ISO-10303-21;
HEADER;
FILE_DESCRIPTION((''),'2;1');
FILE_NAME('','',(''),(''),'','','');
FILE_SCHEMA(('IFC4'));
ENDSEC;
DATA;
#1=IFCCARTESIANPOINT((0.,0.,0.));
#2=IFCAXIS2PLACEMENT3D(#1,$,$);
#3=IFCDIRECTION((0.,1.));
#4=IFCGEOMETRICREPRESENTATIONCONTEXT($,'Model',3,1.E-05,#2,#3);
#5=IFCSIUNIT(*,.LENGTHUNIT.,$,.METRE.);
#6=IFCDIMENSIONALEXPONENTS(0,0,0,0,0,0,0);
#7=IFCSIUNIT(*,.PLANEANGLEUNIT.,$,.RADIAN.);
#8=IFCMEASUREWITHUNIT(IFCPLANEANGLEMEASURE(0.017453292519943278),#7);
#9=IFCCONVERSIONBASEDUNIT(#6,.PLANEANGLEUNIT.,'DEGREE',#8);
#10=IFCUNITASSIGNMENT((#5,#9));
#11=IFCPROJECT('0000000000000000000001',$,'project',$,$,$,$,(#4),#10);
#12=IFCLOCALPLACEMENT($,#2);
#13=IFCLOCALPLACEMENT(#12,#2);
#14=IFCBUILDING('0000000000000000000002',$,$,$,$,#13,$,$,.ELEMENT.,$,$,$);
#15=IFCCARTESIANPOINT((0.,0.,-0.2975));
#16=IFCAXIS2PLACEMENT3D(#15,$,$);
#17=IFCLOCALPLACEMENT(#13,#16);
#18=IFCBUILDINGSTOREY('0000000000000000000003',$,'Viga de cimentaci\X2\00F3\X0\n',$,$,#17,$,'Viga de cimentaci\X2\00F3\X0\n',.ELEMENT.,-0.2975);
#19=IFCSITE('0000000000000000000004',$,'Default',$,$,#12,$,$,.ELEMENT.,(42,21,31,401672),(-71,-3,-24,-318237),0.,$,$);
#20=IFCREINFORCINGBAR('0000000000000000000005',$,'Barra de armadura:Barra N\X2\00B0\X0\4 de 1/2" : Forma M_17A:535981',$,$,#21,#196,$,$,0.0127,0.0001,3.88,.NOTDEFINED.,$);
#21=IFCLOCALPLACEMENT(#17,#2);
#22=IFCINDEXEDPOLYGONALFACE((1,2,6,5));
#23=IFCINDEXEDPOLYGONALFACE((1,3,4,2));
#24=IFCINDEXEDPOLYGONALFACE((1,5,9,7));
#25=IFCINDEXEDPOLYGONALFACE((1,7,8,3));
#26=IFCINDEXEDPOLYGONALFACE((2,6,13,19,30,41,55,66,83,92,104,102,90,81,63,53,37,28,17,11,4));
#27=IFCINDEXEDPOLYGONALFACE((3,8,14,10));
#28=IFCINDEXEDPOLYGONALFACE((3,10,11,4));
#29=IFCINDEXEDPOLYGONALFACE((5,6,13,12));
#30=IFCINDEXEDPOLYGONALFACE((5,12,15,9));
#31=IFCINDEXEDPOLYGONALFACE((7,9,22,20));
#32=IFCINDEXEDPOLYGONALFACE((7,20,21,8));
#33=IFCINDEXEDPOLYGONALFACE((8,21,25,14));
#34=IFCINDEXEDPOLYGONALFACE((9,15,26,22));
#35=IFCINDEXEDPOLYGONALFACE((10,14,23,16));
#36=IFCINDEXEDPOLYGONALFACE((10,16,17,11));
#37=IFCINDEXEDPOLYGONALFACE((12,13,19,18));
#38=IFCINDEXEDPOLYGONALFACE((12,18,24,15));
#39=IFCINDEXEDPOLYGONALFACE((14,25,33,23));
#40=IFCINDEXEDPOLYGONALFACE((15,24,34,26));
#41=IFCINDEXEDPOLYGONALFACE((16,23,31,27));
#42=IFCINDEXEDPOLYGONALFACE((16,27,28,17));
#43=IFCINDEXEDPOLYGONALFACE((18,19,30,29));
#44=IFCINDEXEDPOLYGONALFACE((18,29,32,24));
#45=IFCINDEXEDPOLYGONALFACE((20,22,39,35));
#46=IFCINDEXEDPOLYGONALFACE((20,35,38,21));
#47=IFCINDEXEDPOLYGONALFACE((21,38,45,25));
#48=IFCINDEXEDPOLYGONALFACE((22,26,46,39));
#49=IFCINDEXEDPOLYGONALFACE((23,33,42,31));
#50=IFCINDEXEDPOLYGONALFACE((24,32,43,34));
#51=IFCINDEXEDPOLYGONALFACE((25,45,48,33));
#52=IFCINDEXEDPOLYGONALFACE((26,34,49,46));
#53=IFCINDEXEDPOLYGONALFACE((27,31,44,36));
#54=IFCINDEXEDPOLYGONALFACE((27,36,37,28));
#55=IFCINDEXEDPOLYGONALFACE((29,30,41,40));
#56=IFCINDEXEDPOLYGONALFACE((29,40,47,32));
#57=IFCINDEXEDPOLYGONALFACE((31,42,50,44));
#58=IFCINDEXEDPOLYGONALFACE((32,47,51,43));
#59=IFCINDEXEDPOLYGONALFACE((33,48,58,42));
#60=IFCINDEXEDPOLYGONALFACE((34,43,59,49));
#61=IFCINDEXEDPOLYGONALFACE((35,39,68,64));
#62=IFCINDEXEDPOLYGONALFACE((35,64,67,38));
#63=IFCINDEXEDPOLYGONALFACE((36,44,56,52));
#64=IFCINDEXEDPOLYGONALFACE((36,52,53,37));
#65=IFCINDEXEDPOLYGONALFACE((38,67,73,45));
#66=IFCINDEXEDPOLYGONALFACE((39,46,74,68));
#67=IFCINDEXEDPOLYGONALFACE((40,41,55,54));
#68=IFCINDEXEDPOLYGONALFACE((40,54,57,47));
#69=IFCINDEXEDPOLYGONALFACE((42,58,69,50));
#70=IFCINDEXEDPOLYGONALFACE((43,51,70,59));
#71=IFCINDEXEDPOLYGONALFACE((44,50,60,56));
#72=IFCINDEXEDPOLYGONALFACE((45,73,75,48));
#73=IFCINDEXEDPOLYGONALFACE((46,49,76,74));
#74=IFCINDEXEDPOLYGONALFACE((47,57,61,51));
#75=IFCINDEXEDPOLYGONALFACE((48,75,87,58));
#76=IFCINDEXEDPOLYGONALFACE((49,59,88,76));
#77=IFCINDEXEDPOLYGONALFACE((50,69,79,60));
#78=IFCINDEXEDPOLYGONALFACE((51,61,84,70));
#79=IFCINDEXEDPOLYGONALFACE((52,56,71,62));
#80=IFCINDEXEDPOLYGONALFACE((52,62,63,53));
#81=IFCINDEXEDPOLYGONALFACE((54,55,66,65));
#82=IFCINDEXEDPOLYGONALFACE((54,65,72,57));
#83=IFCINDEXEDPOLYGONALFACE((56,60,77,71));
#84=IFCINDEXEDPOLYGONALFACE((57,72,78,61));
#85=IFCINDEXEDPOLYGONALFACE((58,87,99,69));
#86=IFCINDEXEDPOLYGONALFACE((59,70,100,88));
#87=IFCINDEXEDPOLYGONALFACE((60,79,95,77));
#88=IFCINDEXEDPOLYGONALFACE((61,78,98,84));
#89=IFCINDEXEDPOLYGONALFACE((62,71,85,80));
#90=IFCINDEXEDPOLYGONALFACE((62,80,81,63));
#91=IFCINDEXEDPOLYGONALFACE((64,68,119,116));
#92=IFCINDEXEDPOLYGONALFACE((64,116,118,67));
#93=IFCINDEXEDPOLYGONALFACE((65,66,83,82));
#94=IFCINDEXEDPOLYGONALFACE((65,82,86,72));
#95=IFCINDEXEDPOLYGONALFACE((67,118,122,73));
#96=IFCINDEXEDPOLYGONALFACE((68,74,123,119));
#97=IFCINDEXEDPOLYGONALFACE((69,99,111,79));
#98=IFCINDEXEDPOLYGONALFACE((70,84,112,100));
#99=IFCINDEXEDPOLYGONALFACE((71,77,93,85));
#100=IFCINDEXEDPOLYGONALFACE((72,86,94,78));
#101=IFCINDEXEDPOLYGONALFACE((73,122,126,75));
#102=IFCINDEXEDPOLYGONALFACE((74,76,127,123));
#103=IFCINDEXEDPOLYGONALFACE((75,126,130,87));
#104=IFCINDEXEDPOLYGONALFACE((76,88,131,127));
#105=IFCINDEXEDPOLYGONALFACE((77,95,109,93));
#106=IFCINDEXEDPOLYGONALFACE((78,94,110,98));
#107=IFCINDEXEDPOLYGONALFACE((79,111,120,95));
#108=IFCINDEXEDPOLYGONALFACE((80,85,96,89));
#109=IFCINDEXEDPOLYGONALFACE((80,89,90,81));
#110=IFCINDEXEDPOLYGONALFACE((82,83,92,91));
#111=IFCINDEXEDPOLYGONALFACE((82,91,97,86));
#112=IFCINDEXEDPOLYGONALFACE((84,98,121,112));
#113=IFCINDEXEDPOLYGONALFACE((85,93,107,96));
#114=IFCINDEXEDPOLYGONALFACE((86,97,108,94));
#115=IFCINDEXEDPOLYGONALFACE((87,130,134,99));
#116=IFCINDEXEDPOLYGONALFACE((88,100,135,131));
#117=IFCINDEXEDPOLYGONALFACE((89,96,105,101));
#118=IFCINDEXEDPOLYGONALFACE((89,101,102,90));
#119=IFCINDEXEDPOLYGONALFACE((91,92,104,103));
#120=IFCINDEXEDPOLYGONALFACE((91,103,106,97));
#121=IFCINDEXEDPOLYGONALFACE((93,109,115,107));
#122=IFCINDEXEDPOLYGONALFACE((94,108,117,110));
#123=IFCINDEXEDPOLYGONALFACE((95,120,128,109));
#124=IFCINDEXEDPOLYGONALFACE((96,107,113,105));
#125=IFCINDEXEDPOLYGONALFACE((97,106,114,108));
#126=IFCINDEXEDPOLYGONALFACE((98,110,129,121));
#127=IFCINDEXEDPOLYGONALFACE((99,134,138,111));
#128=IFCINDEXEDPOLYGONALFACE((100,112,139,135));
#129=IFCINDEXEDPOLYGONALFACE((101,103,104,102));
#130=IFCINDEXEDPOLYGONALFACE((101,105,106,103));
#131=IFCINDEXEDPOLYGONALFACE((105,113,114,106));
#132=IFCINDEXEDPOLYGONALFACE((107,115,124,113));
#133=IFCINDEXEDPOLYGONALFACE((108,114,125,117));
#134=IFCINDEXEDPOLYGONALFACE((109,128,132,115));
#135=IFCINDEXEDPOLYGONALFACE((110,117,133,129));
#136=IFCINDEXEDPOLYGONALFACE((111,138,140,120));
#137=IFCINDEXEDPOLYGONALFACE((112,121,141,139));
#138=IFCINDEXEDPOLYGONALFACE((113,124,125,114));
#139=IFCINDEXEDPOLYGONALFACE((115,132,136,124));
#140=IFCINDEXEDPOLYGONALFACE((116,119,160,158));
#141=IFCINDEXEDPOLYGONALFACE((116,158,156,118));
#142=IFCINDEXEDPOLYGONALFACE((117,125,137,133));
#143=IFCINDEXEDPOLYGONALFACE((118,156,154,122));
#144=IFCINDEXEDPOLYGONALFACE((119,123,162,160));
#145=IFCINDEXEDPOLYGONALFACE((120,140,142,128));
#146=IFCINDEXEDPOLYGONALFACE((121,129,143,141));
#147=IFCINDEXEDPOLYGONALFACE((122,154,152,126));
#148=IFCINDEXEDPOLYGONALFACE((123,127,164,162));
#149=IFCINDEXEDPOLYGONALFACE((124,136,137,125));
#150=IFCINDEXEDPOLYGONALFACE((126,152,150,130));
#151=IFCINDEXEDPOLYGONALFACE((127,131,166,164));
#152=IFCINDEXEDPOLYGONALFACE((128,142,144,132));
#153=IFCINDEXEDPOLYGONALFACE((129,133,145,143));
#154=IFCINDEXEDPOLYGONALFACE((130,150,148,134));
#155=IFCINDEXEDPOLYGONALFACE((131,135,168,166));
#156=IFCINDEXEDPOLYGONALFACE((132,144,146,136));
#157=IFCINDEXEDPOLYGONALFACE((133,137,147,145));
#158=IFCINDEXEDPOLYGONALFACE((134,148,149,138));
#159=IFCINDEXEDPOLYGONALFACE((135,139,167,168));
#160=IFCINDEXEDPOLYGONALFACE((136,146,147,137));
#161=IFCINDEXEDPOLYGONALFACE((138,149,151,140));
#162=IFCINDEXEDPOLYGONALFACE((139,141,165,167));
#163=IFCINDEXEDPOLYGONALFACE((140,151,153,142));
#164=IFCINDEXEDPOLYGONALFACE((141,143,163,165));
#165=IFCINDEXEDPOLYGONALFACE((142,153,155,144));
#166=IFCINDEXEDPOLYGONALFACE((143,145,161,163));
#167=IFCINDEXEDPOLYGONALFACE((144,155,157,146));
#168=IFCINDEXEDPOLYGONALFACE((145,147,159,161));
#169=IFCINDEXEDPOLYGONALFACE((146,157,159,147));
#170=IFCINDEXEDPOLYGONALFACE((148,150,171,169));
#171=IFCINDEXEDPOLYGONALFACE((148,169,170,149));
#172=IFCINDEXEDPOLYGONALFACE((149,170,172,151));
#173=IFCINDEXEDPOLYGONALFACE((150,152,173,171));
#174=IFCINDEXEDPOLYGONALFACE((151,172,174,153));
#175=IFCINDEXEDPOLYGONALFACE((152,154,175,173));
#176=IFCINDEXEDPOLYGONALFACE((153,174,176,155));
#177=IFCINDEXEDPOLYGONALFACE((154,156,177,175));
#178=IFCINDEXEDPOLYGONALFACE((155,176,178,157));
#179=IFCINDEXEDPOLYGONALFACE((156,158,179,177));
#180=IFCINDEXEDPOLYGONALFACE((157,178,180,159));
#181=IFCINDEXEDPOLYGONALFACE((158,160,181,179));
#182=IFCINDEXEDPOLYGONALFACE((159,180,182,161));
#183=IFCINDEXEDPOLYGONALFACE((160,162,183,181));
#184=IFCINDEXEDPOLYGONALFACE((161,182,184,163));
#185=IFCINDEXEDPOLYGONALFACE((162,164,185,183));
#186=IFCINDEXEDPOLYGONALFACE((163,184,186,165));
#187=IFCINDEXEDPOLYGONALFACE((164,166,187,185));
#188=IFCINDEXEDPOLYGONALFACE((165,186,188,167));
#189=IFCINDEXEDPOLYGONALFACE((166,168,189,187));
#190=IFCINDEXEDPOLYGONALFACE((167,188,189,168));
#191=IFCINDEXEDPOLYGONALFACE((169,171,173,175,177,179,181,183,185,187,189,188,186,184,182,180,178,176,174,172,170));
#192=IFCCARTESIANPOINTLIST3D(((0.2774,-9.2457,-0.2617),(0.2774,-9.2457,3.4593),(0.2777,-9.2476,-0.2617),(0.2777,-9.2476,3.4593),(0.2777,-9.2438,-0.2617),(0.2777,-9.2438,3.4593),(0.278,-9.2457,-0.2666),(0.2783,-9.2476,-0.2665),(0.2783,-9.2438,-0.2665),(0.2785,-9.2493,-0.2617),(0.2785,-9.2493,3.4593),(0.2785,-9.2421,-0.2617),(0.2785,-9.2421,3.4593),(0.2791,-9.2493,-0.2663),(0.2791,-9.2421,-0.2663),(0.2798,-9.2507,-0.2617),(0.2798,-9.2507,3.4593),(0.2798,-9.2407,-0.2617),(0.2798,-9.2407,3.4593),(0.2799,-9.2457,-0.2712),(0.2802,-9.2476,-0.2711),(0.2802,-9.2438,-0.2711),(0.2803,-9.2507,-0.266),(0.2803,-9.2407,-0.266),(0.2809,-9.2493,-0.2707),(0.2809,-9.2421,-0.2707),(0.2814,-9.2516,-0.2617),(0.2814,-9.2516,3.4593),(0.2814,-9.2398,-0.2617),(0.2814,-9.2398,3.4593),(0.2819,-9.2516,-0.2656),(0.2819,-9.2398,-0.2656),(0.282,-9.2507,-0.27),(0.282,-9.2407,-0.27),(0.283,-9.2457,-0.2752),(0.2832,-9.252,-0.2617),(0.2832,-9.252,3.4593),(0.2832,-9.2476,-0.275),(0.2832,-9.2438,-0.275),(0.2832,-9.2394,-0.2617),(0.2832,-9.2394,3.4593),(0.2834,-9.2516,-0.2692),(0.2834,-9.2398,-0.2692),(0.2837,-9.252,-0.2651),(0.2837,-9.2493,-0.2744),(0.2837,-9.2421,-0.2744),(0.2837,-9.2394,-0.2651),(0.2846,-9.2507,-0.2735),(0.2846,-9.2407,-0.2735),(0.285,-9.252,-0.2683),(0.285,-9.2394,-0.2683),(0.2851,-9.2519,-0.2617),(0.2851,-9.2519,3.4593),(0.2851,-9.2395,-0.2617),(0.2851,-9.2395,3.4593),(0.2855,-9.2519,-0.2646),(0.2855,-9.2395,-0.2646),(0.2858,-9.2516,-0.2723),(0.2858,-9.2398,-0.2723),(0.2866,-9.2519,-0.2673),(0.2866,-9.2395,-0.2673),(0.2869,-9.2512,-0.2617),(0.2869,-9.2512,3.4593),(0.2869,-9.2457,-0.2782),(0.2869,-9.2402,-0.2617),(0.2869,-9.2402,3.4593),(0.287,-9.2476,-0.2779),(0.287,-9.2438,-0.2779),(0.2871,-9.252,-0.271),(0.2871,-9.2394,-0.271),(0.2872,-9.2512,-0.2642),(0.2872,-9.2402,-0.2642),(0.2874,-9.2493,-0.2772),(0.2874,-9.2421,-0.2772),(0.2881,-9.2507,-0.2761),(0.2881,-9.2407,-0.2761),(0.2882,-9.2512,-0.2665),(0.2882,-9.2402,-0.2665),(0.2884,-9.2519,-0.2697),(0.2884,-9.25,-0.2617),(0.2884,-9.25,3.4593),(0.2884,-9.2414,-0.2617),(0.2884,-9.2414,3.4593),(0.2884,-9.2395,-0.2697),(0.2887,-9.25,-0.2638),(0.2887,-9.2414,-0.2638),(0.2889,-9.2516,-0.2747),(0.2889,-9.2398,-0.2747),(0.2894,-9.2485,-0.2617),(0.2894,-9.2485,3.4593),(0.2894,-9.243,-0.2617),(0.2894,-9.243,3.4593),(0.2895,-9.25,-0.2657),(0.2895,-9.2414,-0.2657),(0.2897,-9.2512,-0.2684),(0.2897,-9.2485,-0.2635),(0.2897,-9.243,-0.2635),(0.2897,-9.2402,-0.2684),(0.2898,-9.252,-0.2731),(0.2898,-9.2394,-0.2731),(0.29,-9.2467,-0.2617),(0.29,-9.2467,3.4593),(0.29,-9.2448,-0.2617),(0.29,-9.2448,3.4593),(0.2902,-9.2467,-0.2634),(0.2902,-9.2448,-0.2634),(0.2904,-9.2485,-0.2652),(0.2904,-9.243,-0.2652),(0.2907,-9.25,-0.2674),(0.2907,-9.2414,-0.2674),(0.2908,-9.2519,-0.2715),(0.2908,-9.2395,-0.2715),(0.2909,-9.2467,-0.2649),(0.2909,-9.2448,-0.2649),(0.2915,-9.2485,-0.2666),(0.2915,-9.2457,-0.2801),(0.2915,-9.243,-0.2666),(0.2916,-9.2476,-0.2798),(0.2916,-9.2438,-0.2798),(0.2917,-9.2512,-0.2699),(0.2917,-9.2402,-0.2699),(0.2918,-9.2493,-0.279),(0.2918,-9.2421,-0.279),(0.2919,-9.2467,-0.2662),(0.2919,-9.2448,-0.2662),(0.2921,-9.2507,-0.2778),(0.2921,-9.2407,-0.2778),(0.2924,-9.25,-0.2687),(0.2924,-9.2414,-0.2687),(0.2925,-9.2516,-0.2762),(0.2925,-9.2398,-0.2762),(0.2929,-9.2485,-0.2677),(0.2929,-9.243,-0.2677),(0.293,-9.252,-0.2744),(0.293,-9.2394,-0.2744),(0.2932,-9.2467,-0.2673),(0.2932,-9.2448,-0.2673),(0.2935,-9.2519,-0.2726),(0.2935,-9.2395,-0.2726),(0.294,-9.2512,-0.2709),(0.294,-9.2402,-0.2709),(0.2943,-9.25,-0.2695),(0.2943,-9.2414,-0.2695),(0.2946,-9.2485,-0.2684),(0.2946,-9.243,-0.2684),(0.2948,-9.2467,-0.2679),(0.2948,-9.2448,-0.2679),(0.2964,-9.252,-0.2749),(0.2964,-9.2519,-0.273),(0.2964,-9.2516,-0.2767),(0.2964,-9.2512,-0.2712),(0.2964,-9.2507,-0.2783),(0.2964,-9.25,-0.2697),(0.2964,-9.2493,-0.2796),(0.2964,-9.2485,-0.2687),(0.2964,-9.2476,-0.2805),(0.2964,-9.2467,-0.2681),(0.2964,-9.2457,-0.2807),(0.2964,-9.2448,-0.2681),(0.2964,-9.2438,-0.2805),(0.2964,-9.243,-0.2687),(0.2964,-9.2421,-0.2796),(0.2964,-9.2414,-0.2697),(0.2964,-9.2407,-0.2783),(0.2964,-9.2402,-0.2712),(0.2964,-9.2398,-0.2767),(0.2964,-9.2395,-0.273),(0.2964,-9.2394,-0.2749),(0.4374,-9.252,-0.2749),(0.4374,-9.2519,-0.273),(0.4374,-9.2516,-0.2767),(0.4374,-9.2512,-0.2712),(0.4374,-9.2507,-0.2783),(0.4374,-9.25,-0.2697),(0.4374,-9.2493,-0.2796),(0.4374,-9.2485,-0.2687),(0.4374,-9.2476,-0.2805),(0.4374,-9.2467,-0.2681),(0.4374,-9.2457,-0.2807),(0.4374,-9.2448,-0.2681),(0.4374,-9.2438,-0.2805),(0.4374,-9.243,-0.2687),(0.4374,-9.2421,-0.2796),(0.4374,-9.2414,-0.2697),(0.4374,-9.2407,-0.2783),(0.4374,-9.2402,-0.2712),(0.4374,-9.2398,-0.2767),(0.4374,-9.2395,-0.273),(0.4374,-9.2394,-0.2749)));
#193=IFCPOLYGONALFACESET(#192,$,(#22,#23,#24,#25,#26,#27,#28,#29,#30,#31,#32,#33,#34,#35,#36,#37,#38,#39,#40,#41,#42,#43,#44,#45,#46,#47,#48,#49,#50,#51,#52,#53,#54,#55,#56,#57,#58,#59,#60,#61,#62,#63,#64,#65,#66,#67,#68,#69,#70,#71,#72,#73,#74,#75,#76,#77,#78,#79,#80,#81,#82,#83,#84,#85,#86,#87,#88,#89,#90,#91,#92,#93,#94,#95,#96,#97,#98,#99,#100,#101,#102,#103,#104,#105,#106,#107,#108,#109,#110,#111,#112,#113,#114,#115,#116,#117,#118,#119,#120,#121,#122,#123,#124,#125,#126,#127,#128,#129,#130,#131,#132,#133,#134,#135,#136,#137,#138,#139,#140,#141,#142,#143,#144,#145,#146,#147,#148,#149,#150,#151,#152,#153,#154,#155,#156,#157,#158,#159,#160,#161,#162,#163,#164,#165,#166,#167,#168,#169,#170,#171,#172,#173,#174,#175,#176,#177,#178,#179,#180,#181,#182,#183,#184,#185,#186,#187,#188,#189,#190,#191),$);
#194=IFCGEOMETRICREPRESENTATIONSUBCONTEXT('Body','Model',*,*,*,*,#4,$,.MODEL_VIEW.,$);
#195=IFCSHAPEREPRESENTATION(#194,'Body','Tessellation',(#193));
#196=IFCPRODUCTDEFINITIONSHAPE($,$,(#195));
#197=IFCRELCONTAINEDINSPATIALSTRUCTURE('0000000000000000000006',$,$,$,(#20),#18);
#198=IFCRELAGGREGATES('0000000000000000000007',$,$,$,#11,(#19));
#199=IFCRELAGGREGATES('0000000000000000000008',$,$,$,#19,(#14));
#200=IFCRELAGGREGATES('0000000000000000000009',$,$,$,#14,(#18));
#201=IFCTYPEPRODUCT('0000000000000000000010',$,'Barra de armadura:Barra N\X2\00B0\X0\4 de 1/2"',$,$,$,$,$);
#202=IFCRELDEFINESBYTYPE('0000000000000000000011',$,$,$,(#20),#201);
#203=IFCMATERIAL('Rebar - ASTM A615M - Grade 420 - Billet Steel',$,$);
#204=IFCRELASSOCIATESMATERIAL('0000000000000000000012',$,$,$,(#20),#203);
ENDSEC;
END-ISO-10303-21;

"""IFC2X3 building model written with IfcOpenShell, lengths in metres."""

from ifc_helpers import new_model, entity, si_unit, converted_unit, direction, frame, origin, place, context, subcontext, project, spatial, material, type_object, element, save


model = new_model("IFC2X3")

# Units and contexts
model_context = context("Model", 3, precision=1e-05, world=origin(), true_north=direction((0.0, 1.0)))
body_context = subcontext(model_context, "Body", "Model", "MODEL_VIEW")
ifc_project = project(units=[si_unit("LENGTHUNIT", "METRE"), converted_unit("PLANEANGLEUNIT", "DEGREE", entity("IfcPlaneAngleMeasure", 0.017453292519943278), si_unit("PLANEANGLEUNIT", "RADIAN"), dimensions=[0, 0, 0, 0, 0, 0, 0])], contexts=[model_context])

# Site, building, storey
site_placement = place(None, origin())
site = spatial("IfcSite", under=ifc_project, at=site_placement, Name="Default", CompositionType="ELEMENT", RefLatitude=(42, 21, 31, 401672), RefLongitude=(-71, -3, -24, -318237), RefElevation=0.0)
building_placement = place(site_placement, origin())
building = spatial("IfcBuilding", under=site, at=building_placement, CompositionType="ELEMENT")
storey_placement = place(building_placement, frame((0.0, 0.0, -0.2975)))
storey = spatial("IfcBuildingStorey", under=building, at=storey_placement, Name="Viga de cimentación", LongName="Viga de cimentación", CompositionType="ELEMENT", Elevation=-0.2975)

# Reinforcing bar
ifc_material = material(Name="Rebar - ASTM A615M - Grade 420 - Billet Steel")
type_product_1 = type_object("IfcTypeProduct", Name="Barra de armadura:Barra N°4 de 1/2\"")
reinforcing_bar_1_placement = place(storey_placement, origin())
element("IfcReinforcingBar", 1, at=reinforcing_bar_1_placement, inside=storey, type_object=type_product_1, material=ifc_material, Name="Barra de armadura:Barra N°4 de 1/2\" : Forma M_17A:535981", BarLength=3.88, BarRole="NOTDEFINED", CrossSectionArea=0.0001, NominalDiameter=0.0127, context=body_context, shape_type="AdvancedSweptSolid", body=[
    entity("IfcSweptDiskSolid", entity("IfcCompositeCurve", [entity("IfcCompositeCurveSegment", "CONTINUOUS", True, entity("IfcPolyline", [entity("IfcCartesianPoint", [0.2837, -9.2457, 3.4593]), entity("IfcCartesianPoint", [0.2837, -9.2457, -0.2617])])), entity("IfcCompositeCurveSegment", "CONTINUOUS", True, entity("IfcTrimmedCurve", entity("IfcCircle", entity("IfcAxis2Placement3D", entity("IfcCartesianPoint", [0.2964, -9.2457, -0.2617]), entity("IfcDirection", [0.0, -1.0, 0.0]), entity("IfcDirection", [0.0, 0.0, -1.0])), 0.0127), [entity("IfcParameterValue", 270.0)], [entity("IfcParameterValue", 360.0)], True, "PARAMETER")), entity("IfcCompositeCurveSegment", "CONTINUOUS", True, entity("IfcPolyline", [entity("IfcCartesianPoint", [0.2964, -9.2457, -0.2744]), entity("IfcCartesianPoint", [0.4374, -9.2457, -0.2744])]))], False), 0.0063, None, 0.0, 92.0),
])

save(model, "model.ifc")
